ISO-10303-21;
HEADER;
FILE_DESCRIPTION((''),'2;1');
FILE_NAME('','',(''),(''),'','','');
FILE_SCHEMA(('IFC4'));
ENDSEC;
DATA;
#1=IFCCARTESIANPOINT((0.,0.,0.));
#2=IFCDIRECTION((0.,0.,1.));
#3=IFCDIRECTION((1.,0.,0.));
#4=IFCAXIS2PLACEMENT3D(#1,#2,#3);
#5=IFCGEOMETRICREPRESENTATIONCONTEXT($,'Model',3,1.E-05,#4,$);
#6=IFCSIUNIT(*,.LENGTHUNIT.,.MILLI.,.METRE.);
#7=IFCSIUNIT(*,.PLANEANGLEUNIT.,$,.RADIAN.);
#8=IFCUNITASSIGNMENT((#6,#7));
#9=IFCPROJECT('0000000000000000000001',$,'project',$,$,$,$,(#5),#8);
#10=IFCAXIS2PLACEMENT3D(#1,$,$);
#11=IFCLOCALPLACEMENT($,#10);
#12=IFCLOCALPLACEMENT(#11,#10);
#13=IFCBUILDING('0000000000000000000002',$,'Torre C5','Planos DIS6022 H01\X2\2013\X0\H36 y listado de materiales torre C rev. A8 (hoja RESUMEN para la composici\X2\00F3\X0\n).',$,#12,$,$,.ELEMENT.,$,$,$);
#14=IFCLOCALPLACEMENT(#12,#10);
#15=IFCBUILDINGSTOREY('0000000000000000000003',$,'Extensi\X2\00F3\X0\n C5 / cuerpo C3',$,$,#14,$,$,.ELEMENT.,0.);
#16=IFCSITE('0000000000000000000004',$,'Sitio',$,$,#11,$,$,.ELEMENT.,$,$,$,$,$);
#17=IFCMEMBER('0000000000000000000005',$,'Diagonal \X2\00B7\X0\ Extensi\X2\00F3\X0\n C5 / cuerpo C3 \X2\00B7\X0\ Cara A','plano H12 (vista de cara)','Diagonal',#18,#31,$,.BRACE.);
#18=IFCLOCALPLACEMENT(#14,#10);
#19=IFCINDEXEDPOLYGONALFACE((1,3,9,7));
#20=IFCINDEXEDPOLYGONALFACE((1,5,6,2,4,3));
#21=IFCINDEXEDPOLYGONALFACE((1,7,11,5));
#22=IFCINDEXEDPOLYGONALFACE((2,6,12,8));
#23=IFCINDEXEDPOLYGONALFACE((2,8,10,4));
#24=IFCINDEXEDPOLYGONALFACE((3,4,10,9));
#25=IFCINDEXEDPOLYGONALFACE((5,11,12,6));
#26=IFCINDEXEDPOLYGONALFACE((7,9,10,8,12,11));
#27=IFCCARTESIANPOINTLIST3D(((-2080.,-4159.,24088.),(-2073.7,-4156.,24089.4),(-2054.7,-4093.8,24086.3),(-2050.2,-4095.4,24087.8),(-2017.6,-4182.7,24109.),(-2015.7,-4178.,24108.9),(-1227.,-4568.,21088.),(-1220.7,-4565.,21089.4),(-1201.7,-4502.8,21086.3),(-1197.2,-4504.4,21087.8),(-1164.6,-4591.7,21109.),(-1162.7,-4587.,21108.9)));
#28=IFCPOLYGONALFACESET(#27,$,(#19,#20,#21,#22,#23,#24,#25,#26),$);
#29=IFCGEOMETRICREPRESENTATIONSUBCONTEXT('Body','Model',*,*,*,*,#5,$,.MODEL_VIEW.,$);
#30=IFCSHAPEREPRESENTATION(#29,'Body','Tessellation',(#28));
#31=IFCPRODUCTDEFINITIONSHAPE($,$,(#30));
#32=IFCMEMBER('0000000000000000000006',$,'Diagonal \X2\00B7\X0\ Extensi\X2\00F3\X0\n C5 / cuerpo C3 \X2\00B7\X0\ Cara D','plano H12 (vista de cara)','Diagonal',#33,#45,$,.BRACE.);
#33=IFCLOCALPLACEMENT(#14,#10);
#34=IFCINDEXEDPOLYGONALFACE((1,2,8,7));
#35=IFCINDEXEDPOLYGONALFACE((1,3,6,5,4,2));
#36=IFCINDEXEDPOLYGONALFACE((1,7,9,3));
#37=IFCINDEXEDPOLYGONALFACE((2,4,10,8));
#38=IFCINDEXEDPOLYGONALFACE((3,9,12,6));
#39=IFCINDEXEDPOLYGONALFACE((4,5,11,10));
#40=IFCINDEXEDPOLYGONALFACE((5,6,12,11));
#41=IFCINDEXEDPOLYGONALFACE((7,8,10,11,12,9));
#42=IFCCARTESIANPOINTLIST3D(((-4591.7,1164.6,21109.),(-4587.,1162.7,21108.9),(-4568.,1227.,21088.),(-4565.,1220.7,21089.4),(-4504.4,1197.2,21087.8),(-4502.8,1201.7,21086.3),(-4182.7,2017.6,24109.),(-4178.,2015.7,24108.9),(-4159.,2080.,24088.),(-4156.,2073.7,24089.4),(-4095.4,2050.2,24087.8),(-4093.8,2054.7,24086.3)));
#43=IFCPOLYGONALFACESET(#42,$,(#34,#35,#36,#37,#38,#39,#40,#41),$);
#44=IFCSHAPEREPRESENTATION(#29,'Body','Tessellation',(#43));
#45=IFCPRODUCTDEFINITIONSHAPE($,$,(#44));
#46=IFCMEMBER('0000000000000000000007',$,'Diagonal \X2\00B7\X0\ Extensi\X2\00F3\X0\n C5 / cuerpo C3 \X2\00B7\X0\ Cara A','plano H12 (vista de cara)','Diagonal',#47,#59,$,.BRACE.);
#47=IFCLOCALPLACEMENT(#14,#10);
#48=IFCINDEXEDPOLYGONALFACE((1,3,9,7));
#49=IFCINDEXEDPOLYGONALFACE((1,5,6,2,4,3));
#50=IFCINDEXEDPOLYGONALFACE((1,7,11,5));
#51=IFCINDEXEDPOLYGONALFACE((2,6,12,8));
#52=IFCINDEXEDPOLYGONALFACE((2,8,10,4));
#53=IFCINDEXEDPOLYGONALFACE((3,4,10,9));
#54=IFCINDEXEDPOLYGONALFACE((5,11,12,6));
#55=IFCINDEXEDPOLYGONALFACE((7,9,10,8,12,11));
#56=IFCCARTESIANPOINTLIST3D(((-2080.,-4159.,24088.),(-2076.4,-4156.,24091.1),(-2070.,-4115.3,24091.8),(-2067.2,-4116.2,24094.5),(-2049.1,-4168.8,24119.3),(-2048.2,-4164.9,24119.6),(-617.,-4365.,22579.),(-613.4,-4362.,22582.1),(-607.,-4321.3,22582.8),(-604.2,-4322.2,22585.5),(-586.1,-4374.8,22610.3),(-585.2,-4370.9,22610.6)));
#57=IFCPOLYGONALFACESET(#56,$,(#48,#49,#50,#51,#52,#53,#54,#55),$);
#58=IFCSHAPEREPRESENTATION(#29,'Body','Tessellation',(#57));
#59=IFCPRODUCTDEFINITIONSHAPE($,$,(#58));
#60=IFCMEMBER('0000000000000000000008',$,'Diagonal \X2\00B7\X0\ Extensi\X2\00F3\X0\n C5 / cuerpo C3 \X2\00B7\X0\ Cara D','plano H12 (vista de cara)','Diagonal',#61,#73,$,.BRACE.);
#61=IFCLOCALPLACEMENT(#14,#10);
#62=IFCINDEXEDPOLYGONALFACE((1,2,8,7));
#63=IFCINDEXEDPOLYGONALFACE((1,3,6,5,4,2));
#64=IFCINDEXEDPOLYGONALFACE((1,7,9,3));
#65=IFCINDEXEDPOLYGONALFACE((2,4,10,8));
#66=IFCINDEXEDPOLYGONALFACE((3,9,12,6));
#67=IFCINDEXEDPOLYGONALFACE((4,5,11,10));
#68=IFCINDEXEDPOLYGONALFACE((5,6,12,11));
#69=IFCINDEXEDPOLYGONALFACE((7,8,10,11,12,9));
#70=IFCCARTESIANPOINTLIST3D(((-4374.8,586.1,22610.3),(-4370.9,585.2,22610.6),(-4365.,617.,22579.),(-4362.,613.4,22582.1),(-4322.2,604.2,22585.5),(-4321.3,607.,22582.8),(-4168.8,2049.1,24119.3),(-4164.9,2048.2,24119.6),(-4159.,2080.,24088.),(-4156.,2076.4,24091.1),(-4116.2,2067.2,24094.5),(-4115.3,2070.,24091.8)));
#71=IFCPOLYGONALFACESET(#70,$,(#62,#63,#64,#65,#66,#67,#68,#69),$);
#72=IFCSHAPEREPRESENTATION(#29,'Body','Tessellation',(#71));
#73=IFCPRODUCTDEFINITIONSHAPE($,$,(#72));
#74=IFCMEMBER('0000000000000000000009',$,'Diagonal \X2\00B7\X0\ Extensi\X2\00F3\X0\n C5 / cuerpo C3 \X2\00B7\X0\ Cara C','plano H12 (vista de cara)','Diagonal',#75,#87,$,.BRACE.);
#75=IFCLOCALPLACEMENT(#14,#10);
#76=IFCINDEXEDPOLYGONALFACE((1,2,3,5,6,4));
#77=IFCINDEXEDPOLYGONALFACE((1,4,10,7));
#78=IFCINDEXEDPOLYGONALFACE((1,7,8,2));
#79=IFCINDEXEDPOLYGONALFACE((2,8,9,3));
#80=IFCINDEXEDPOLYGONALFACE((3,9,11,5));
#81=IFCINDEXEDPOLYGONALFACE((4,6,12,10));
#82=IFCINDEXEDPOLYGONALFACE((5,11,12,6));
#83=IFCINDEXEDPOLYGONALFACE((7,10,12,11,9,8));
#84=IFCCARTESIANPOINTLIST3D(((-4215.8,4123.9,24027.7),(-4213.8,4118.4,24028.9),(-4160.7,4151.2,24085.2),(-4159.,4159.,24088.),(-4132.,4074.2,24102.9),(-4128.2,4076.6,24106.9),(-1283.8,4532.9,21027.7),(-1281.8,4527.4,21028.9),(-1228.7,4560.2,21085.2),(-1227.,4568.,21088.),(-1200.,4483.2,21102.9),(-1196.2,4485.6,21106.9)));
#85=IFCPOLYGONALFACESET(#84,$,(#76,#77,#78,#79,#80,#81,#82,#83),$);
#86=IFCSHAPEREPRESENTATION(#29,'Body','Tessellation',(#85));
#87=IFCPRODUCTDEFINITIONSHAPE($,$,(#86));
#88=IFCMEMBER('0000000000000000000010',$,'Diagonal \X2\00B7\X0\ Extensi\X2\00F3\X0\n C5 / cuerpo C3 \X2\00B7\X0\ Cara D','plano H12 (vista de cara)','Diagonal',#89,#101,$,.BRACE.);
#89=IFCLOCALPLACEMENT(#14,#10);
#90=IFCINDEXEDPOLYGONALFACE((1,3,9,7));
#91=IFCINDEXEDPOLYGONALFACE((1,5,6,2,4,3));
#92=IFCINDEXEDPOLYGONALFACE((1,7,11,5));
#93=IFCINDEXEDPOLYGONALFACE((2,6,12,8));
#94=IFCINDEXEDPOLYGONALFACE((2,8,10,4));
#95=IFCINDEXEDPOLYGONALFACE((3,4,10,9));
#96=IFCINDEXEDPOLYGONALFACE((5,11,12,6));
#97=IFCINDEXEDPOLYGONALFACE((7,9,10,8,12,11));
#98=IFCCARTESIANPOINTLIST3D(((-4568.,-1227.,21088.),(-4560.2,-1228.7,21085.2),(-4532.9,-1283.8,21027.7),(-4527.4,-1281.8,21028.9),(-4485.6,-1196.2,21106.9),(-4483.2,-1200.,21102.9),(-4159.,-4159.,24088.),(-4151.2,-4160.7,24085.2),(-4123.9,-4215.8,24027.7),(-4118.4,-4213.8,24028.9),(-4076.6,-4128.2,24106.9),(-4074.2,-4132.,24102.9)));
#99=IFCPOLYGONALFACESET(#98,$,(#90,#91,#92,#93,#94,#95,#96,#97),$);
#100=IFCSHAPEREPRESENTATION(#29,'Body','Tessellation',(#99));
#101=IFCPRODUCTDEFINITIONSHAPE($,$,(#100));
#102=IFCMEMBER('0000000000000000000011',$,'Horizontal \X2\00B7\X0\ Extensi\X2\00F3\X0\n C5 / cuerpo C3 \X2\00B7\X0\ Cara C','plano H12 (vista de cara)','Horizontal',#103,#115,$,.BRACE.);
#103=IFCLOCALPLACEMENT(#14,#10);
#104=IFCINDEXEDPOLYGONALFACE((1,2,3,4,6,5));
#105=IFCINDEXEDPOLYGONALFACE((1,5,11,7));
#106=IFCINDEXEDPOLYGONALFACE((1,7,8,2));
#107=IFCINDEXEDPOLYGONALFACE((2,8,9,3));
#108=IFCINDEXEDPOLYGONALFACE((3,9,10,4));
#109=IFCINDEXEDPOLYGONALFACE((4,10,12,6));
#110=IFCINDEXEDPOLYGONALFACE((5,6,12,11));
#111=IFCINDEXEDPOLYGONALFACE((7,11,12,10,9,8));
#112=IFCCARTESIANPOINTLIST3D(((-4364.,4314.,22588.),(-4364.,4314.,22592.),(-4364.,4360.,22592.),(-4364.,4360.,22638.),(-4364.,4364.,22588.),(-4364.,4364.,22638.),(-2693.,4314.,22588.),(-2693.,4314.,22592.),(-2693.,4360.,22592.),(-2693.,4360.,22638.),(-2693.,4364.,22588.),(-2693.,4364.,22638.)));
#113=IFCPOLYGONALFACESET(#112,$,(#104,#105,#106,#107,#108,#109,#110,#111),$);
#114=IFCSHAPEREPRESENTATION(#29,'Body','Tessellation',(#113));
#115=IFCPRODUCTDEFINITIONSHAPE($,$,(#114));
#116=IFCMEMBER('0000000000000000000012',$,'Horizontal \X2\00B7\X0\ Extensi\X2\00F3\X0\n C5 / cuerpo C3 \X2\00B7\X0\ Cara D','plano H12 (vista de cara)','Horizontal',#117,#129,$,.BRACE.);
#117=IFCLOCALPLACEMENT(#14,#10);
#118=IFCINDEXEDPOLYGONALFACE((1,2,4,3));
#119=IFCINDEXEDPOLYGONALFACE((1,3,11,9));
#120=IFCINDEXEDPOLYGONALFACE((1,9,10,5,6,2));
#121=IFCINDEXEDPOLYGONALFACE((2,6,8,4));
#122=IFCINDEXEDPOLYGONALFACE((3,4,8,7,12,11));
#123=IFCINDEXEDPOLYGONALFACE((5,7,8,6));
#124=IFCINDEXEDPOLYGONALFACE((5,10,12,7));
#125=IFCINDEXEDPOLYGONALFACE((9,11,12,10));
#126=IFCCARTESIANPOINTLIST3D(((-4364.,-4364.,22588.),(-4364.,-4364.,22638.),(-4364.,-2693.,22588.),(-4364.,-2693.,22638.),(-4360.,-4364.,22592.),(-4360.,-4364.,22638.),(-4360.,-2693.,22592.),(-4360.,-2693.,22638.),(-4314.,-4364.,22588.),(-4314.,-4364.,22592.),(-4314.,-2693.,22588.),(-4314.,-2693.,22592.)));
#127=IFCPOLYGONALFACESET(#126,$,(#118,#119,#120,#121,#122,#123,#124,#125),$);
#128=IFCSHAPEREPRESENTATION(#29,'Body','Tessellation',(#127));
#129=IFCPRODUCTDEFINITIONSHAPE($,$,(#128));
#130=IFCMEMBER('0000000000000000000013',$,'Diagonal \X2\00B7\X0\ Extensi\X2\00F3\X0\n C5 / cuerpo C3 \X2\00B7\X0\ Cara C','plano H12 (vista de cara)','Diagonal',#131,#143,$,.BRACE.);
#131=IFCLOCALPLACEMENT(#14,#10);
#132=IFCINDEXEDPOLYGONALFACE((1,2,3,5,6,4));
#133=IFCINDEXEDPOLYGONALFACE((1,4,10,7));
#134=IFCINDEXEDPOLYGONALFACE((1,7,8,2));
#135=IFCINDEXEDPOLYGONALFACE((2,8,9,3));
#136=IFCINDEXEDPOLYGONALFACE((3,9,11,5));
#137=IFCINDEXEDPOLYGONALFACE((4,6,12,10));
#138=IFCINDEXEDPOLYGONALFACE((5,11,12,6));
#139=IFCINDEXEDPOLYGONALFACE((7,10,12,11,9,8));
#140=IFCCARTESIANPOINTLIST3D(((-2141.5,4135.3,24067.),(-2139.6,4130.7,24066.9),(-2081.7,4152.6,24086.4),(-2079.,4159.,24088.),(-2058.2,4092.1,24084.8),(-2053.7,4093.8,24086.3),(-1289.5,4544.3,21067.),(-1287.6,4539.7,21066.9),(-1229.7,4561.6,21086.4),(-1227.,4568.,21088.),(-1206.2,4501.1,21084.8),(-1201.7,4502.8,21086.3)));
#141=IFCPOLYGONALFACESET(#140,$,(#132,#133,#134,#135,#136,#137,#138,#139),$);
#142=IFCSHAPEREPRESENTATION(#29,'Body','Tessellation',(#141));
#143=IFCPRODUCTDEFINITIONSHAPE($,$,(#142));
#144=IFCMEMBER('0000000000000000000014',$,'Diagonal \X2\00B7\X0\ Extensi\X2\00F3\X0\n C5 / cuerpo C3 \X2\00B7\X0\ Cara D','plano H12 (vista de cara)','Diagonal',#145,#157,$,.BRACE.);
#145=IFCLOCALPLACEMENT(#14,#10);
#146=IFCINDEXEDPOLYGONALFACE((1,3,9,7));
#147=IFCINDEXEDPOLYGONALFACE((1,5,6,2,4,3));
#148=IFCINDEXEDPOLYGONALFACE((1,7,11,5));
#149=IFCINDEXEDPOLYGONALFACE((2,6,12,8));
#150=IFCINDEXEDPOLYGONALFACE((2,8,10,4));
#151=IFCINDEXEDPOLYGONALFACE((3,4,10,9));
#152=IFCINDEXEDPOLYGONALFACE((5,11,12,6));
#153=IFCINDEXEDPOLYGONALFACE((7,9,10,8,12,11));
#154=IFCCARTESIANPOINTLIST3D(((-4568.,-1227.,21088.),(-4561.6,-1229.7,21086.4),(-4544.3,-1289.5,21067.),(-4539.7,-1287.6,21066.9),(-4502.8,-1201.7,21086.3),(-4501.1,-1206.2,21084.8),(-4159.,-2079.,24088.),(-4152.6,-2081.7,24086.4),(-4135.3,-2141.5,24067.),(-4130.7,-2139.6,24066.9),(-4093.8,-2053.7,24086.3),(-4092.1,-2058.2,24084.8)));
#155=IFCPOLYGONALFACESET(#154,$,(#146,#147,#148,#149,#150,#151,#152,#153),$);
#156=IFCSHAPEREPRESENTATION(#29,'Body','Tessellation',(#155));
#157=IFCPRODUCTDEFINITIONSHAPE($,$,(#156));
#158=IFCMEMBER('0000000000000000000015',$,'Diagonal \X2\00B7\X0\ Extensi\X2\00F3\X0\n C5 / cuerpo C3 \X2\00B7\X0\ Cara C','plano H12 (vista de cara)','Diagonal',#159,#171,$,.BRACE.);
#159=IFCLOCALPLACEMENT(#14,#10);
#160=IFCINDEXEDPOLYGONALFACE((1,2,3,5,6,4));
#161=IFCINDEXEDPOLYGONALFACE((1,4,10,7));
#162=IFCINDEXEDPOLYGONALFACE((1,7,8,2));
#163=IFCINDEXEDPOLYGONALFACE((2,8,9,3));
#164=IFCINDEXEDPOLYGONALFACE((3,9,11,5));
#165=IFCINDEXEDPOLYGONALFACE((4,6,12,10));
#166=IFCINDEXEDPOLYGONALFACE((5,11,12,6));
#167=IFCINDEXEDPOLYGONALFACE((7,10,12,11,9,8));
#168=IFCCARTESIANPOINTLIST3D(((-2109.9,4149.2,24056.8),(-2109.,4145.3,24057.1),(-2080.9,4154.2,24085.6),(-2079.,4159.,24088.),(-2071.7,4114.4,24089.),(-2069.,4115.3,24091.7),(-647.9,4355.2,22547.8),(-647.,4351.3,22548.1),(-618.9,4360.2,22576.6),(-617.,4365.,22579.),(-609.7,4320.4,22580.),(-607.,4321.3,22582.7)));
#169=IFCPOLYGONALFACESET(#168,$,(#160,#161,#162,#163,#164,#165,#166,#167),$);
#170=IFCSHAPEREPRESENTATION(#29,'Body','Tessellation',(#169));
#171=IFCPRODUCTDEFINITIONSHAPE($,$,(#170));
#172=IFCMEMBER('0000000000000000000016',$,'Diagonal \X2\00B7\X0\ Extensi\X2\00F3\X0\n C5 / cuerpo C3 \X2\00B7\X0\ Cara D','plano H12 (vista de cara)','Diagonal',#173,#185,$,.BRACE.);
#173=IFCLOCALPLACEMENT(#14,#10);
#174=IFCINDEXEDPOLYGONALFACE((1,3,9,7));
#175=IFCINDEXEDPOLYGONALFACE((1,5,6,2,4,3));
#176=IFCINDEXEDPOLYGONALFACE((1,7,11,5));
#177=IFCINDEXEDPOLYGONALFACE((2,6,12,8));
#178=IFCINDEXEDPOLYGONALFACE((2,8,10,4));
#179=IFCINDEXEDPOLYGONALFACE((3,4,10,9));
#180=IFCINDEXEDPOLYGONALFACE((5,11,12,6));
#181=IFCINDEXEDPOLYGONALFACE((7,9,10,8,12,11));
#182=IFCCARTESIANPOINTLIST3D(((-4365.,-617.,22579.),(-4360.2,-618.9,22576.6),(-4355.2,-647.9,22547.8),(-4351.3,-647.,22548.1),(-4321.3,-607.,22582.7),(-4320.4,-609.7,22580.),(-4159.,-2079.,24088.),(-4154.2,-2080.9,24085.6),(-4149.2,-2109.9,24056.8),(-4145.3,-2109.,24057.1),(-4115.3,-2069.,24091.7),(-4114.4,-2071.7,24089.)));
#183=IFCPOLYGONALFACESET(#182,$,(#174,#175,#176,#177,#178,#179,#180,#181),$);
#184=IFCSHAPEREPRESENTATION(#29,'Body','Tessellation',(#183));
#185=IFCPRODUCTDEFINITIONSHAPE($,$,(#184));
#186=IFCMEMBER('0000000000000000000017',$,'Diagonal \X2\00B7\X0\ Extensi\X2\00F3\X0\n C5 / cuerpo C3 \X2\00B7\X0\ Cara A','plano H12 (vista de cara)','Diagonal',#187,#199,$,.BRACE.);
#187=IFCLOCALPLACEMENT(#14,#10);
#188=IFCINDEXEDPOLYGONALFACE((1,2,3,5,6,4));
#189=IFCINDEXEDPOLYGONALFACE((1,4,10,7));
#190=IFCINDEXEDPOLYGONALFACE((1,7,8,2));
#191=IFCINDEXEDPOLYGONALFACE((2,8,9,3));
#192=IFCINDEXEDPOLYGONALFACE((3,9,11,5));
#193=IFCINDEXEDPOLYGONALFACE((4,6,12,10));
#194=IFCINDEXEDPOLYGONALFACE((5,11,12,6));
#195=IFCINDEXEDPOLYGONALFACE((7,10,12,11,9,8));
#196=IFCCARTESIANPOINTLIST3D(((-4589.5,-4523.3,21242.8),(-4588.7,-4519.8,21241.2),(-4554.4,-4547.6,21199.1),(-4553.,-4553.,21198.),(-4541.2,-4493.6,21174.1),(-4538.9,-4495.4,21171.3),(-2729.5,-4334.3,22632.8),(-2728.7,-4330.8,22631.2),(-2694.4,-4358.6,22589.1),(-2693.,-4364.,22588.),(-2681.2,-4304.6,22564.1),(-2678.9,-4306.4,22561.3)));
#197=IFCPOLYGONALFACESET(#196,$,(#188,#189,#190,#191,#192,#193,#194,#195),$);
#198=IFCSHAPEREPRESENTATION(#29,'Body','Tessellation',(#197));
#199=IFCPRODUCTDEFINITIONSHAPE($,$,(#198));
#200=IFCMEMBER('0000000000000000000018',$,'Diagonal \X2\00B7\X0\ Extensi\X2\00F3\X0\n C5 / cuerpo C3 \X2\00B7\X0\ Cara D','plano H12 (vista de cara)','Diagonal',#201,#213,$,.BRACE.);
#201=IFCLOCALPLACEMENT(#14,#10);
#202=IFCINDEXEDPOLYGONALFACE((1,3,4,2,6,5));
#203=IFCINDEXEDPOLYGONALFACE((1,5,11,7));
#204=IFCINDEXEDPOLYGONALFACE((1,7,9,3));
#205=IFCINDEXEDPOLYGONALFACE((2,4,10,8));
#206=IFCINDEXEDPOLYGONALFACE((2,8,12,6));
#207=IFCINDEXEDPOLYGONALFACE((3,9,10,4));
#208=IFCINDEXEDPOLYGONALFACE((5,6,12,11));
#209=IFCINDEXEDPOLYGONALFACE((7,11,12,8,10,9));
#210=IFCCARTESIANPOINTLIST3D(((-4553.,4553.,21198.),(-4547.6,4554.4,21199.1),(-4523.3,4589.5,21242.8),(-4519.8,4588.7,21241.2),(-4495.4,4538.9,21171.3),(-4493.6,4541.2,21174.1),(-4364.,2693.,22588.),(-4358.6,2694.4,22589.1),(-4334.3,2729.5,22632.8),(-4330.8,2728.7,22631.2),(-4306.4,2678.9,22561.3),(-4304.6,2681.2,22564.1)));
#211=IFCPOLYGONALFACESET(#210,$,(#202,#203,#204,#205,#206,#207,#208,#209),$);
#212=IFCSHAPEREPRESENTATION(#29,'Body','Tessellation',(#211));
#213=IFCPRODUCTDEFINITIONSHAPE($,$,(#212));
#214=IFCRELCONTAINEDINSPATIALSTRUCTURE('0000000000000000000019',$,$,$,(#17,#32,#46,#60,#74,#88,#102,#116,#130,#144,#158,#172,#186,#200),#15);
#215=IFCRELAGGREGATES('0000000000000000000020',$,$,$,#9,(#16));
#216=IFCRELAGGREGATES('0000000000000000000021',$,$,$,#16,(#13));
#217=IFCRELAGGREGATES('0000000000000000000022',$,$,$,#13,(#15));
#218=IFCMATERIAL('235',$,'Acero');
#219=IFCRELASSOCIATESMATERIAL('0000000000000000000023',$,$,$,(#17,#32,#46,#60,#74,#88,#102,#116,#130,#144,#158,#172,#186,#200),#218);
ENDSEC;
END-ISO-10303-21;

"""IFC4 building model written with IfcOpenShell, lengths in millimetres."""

from ifc_helpers import new_model, si_unit, frame, frame_2d, origin, origin_with_axes, place, context, subcontext, project, spatial, l_section, extrude, material, element, save


model = new_model("IFC4")

# Units and contexts
model_context = context("Model", 3, precision=1e-05, world=origin_with_axes())
body_context = subcontext(model_context, "Body", "Model", "MODEL_VIEW")
ifc_project = project(units=[si_unit("LENGTHUNIT", "METRE", prefix="MILLI"), si_unit("PLANEANGLEUNIT", "RADIAN")], contexts=[model_context])

# Site, building, storey
site_placement = place(None, origin())
site = spatial("IfcSite", under=ifc_project, at=site_placement, Name="Sitio", CompositionType="ELEMENT")
building_placement = place(site_placement, origin())
building = spatial("IfcBuilding", under=site, at=building_placement, Name="Torre C5", Description="Planos DIS6022 H01–H36 y listado de materiales torre C rev. A8 (hoja RESUMEN para la composición).", CompositionType="ELEMENT")
storey_placement = place(building_placement, origin())
storey = spatial("IfcBuildingStorey", under=building, at=storey_placement, Name="Extensión C5 / cuerpo C3", CompositionType="ELEMENT", Elevation=0.0)

# Members
ifc_material_1 = material(Name="235", Category="Acero")
for number, where, z_axis, x_axis, name in (
    (1, (-2080.0, -4159.0, 24088.0), (0.271171, -0.130022, -0.953709), (0.361382, 0.932101, -0.024323), "Diagonal · Extensión C5 / cuerpo C3 · Cara A"),
    (2, (-4159.0, 2080.0, 24088.0), (-0.130022, -0.271171, -0.953709), (0.932101, -0.361382, -0.024323), "Diagonal · Extensión C5 / cuerpo C3 · Cara D"),
):
    element("IfcMember", number, at=place(storey_placement, frame(where, z_axis=z_axis, x_axis=x_axis)), inside=storey, material=ifc_material_1, Name=name, Description="plano H12 (vista de cara)", ObjectType="Diagonal", PredefinedType="BRACE", context=body_context, shape_type="SweptSolid", body=[
        extrude(l_section(Depth=70.0, Width=70.0, Thickness=5.0, at=frame_2d((35.0, 35.0))), None, (0.0, 0.0, 1.0), 3145.6),
    ])
for number, where, z_axis, x_axis, name in (
    (3, (-2080.0, -4159.0, 24088.0), (0.692759, -0.097545, -0.714541), (0.22282, 0.971283, 0.083434), "Diagonal · Extensión C5 / cuerpo C3 · Cara A"),
    (4, (-4159.0, 2080.0, 24088.0), (-0.097545, -0.692759, -0.714541), (0.971283, -0.22282, 0.083434), "Diagonal · Extensión C5 / cuerpo C3 · Cara D"),
):
    element("IfcMember", number, at=place(storey_placement, frame(where, z_axis=z_axis, x_axis=x_axis)), inside=storey, material=ifc_material_1, Name=name, Description="plano H12 (vista de cara)", ObjectType="Diagonal", PredefinedType="BRACE", context=body_context, shape_type="SweptSolid", body=[
        extrude(l_section(Depth=45.0, Width=45.0, Thickness=4.0, at=frame_2d((22.5, 22.5))), None, (0.0, 0.0, 1.0), 2111.8),
    ])
for number, where, z_axis, x_axis, name in (
    (5, (-4159.0, 4159.0, 24088.0), (0.695656, 0.097041, -0.71179), (0.342458, -0.9158, 0.209842), "Diagonal · Extensión C5 / cuerpo C3 · Cara C"),
    (6, (-4159.0, -4159.0, 24088.0), (-0.097041, 0.695656, -0.71179), (0.9158, 0.342458, 0.209842), "Diagonal · Extensión C5 / cuerpo C3 · Cara D"),
):
    element("IfcMember", number, at=place(storey_placement, frame(where, z_axis=z_axis, x_axis=x_axis)), inside=storey, material=ifc_material_1, Name=name, Description="plano H12 (vista de cara)", ObjectType="Diagonal", PredefinedType="BRACE", context=body_context, shape_type="SweptSolid", body=[
        extrude(l_section(Depth=90.0, Width=90.0, Thickness=6.0, at=frame_2d((45.0, 45.0))), None, (0.0, 0.0, 1.0), 4214.7),
    ])
for number, where, z_axis, x_axis, name in (
    (7, (-2693.0, 4364.0, 22588.0), (-1.0, 0.0, 0.0), (0.0, -1.0, 0.0), "Horizontal · Extensión C5 / cuerpo C3 · Cara C"),
    (8, (-4364.0, -2693.0, 22588.0), (0.0, -1.0, 0.0), (1.0, 0.0, 0.0), "Horizontal · Extensión C5 / cuerpo C3 · Cara D"),
):
    element("IfcMember", number, at=place(storey_placement, frame(where, z_axis=z_axis, x_axis=x_axis)), inside=storey, material=ifc_material_1, Name=name, Description="plano H12 (vista de cara)", ObjectType="Horizontal", PredefinedType="BRACE", context=body_context, shape_type="SweptSolid", body=[
        extrude(l_section(Depth=50.0, Width=50.0, Thickness=4.0, at=frame_2d((25.0, 25.0))), None, (0.0, 0.0, 1.0), 1671.0),
    ])
for number, where, z_axis, x_axis, name in (
    (9, (-2079.0, 4159.0, 24088.0), (0.270877, 0.130033, -0.953791), (0.361321, -0.93212, -0.024464), "Diagonal · Extensión C5 / cuerpo C3 · Cara C"),
    (10, (-4159.0, -2079.0, 24088.0), (-0.130033, 0.270877, -0.953791), (0.93212, 0.361321, -0.024464), "Diagonal · Extensión C5 / cuerpo C3 · Cara D"),
):
    element("IfcMember", number, at=place(storey_placement, frame(where, z_axis=z_axis, x_axis=x_axis)), inside=storey, material=ifc_material_1, Name=name, Description="plano H12 (vista de cara)", ObjectType="Diagonal", PredefinedType="BRACE", context=body_context, shape_type="SweptSolid", body=[
        extrude(l_section(Depth=70.0, Width=70.0, Thickness=5.0, at=frame_2d((35.0, 35.0))), None, (0.0, 0.0, 1.0), 3145.3),
    ])
for number, where, z_axis, x_axis, name in (
    (11, (-2079.0, 4159.0, 24088.0), (0.692513, 0.097577, -0.714776), (0.222866, -0.971281, 0.083331), "Diagonal · Extensión C5 / cuerpo C3 · Cara C"),
    (12, (-4159.0, -2079.0, 24088.0), (-0.097577, 0.692513, -0.714776), (0.971281, 0.222866, 0.083331), "Diagonal · Extensión C5 / cuerpo C3 · Cara D"),
):
    element("IfcMember", number, at=place(storey_placement, frame(where, z_axis=z_axis, x_axis=x_axis)), inside=storey, material=ifc_material_1, Name=name, Description="plano H12 (vista de cara)", ObjectType="Diagonal", PredefinedType="BRACE", context=body_context, shape_type="SweptSolid", body=[
        extrude(l_section(Depth=45.0, Width=45.0, Thickness=4.0, at=frame_2d((22.5, 22.5))), None, (0.0, 0.0, 1.0), 2111.2),
    ])
for number, where, z_axis, x_axis, name in (
    (13, (-4553.0, -4553.0, 21198.0), (0.798392, 0.081127, 0.596648), (0.216463, 0.885971, -0.410122), "Diagonal · Extensión C5 / cuerpo C3 · Cara A"),
    (14, (-4553.0, 4553.0, 21198.0), (0.081127, -0.798392, 0.596648), (0.885971, -0.216463, -0.410122), "Diagonal · Extensión C5 / cuerpo C3 · Cara D"),
):
    element("IfcMember", number, at=place(storey_placement, frame(where, z_axis=z_axis, x_axis=x_axis)), inside=storey, material=ifc_material_1, Name=name, Description="plano H12 (vista de cara)", ObjectType="Diagonal", PredefinedType="BRACE", context=body_context, shape_type="SweptSolid", body=[
        extrude(l_section(Depth=65.0, Width=65.0, Thickness=4.0, at=frame_2d((32.5, 32.5))), None, (0.0, 0.0, 1.0), 2329.7),
    ])

save(model, "model.ifc")
